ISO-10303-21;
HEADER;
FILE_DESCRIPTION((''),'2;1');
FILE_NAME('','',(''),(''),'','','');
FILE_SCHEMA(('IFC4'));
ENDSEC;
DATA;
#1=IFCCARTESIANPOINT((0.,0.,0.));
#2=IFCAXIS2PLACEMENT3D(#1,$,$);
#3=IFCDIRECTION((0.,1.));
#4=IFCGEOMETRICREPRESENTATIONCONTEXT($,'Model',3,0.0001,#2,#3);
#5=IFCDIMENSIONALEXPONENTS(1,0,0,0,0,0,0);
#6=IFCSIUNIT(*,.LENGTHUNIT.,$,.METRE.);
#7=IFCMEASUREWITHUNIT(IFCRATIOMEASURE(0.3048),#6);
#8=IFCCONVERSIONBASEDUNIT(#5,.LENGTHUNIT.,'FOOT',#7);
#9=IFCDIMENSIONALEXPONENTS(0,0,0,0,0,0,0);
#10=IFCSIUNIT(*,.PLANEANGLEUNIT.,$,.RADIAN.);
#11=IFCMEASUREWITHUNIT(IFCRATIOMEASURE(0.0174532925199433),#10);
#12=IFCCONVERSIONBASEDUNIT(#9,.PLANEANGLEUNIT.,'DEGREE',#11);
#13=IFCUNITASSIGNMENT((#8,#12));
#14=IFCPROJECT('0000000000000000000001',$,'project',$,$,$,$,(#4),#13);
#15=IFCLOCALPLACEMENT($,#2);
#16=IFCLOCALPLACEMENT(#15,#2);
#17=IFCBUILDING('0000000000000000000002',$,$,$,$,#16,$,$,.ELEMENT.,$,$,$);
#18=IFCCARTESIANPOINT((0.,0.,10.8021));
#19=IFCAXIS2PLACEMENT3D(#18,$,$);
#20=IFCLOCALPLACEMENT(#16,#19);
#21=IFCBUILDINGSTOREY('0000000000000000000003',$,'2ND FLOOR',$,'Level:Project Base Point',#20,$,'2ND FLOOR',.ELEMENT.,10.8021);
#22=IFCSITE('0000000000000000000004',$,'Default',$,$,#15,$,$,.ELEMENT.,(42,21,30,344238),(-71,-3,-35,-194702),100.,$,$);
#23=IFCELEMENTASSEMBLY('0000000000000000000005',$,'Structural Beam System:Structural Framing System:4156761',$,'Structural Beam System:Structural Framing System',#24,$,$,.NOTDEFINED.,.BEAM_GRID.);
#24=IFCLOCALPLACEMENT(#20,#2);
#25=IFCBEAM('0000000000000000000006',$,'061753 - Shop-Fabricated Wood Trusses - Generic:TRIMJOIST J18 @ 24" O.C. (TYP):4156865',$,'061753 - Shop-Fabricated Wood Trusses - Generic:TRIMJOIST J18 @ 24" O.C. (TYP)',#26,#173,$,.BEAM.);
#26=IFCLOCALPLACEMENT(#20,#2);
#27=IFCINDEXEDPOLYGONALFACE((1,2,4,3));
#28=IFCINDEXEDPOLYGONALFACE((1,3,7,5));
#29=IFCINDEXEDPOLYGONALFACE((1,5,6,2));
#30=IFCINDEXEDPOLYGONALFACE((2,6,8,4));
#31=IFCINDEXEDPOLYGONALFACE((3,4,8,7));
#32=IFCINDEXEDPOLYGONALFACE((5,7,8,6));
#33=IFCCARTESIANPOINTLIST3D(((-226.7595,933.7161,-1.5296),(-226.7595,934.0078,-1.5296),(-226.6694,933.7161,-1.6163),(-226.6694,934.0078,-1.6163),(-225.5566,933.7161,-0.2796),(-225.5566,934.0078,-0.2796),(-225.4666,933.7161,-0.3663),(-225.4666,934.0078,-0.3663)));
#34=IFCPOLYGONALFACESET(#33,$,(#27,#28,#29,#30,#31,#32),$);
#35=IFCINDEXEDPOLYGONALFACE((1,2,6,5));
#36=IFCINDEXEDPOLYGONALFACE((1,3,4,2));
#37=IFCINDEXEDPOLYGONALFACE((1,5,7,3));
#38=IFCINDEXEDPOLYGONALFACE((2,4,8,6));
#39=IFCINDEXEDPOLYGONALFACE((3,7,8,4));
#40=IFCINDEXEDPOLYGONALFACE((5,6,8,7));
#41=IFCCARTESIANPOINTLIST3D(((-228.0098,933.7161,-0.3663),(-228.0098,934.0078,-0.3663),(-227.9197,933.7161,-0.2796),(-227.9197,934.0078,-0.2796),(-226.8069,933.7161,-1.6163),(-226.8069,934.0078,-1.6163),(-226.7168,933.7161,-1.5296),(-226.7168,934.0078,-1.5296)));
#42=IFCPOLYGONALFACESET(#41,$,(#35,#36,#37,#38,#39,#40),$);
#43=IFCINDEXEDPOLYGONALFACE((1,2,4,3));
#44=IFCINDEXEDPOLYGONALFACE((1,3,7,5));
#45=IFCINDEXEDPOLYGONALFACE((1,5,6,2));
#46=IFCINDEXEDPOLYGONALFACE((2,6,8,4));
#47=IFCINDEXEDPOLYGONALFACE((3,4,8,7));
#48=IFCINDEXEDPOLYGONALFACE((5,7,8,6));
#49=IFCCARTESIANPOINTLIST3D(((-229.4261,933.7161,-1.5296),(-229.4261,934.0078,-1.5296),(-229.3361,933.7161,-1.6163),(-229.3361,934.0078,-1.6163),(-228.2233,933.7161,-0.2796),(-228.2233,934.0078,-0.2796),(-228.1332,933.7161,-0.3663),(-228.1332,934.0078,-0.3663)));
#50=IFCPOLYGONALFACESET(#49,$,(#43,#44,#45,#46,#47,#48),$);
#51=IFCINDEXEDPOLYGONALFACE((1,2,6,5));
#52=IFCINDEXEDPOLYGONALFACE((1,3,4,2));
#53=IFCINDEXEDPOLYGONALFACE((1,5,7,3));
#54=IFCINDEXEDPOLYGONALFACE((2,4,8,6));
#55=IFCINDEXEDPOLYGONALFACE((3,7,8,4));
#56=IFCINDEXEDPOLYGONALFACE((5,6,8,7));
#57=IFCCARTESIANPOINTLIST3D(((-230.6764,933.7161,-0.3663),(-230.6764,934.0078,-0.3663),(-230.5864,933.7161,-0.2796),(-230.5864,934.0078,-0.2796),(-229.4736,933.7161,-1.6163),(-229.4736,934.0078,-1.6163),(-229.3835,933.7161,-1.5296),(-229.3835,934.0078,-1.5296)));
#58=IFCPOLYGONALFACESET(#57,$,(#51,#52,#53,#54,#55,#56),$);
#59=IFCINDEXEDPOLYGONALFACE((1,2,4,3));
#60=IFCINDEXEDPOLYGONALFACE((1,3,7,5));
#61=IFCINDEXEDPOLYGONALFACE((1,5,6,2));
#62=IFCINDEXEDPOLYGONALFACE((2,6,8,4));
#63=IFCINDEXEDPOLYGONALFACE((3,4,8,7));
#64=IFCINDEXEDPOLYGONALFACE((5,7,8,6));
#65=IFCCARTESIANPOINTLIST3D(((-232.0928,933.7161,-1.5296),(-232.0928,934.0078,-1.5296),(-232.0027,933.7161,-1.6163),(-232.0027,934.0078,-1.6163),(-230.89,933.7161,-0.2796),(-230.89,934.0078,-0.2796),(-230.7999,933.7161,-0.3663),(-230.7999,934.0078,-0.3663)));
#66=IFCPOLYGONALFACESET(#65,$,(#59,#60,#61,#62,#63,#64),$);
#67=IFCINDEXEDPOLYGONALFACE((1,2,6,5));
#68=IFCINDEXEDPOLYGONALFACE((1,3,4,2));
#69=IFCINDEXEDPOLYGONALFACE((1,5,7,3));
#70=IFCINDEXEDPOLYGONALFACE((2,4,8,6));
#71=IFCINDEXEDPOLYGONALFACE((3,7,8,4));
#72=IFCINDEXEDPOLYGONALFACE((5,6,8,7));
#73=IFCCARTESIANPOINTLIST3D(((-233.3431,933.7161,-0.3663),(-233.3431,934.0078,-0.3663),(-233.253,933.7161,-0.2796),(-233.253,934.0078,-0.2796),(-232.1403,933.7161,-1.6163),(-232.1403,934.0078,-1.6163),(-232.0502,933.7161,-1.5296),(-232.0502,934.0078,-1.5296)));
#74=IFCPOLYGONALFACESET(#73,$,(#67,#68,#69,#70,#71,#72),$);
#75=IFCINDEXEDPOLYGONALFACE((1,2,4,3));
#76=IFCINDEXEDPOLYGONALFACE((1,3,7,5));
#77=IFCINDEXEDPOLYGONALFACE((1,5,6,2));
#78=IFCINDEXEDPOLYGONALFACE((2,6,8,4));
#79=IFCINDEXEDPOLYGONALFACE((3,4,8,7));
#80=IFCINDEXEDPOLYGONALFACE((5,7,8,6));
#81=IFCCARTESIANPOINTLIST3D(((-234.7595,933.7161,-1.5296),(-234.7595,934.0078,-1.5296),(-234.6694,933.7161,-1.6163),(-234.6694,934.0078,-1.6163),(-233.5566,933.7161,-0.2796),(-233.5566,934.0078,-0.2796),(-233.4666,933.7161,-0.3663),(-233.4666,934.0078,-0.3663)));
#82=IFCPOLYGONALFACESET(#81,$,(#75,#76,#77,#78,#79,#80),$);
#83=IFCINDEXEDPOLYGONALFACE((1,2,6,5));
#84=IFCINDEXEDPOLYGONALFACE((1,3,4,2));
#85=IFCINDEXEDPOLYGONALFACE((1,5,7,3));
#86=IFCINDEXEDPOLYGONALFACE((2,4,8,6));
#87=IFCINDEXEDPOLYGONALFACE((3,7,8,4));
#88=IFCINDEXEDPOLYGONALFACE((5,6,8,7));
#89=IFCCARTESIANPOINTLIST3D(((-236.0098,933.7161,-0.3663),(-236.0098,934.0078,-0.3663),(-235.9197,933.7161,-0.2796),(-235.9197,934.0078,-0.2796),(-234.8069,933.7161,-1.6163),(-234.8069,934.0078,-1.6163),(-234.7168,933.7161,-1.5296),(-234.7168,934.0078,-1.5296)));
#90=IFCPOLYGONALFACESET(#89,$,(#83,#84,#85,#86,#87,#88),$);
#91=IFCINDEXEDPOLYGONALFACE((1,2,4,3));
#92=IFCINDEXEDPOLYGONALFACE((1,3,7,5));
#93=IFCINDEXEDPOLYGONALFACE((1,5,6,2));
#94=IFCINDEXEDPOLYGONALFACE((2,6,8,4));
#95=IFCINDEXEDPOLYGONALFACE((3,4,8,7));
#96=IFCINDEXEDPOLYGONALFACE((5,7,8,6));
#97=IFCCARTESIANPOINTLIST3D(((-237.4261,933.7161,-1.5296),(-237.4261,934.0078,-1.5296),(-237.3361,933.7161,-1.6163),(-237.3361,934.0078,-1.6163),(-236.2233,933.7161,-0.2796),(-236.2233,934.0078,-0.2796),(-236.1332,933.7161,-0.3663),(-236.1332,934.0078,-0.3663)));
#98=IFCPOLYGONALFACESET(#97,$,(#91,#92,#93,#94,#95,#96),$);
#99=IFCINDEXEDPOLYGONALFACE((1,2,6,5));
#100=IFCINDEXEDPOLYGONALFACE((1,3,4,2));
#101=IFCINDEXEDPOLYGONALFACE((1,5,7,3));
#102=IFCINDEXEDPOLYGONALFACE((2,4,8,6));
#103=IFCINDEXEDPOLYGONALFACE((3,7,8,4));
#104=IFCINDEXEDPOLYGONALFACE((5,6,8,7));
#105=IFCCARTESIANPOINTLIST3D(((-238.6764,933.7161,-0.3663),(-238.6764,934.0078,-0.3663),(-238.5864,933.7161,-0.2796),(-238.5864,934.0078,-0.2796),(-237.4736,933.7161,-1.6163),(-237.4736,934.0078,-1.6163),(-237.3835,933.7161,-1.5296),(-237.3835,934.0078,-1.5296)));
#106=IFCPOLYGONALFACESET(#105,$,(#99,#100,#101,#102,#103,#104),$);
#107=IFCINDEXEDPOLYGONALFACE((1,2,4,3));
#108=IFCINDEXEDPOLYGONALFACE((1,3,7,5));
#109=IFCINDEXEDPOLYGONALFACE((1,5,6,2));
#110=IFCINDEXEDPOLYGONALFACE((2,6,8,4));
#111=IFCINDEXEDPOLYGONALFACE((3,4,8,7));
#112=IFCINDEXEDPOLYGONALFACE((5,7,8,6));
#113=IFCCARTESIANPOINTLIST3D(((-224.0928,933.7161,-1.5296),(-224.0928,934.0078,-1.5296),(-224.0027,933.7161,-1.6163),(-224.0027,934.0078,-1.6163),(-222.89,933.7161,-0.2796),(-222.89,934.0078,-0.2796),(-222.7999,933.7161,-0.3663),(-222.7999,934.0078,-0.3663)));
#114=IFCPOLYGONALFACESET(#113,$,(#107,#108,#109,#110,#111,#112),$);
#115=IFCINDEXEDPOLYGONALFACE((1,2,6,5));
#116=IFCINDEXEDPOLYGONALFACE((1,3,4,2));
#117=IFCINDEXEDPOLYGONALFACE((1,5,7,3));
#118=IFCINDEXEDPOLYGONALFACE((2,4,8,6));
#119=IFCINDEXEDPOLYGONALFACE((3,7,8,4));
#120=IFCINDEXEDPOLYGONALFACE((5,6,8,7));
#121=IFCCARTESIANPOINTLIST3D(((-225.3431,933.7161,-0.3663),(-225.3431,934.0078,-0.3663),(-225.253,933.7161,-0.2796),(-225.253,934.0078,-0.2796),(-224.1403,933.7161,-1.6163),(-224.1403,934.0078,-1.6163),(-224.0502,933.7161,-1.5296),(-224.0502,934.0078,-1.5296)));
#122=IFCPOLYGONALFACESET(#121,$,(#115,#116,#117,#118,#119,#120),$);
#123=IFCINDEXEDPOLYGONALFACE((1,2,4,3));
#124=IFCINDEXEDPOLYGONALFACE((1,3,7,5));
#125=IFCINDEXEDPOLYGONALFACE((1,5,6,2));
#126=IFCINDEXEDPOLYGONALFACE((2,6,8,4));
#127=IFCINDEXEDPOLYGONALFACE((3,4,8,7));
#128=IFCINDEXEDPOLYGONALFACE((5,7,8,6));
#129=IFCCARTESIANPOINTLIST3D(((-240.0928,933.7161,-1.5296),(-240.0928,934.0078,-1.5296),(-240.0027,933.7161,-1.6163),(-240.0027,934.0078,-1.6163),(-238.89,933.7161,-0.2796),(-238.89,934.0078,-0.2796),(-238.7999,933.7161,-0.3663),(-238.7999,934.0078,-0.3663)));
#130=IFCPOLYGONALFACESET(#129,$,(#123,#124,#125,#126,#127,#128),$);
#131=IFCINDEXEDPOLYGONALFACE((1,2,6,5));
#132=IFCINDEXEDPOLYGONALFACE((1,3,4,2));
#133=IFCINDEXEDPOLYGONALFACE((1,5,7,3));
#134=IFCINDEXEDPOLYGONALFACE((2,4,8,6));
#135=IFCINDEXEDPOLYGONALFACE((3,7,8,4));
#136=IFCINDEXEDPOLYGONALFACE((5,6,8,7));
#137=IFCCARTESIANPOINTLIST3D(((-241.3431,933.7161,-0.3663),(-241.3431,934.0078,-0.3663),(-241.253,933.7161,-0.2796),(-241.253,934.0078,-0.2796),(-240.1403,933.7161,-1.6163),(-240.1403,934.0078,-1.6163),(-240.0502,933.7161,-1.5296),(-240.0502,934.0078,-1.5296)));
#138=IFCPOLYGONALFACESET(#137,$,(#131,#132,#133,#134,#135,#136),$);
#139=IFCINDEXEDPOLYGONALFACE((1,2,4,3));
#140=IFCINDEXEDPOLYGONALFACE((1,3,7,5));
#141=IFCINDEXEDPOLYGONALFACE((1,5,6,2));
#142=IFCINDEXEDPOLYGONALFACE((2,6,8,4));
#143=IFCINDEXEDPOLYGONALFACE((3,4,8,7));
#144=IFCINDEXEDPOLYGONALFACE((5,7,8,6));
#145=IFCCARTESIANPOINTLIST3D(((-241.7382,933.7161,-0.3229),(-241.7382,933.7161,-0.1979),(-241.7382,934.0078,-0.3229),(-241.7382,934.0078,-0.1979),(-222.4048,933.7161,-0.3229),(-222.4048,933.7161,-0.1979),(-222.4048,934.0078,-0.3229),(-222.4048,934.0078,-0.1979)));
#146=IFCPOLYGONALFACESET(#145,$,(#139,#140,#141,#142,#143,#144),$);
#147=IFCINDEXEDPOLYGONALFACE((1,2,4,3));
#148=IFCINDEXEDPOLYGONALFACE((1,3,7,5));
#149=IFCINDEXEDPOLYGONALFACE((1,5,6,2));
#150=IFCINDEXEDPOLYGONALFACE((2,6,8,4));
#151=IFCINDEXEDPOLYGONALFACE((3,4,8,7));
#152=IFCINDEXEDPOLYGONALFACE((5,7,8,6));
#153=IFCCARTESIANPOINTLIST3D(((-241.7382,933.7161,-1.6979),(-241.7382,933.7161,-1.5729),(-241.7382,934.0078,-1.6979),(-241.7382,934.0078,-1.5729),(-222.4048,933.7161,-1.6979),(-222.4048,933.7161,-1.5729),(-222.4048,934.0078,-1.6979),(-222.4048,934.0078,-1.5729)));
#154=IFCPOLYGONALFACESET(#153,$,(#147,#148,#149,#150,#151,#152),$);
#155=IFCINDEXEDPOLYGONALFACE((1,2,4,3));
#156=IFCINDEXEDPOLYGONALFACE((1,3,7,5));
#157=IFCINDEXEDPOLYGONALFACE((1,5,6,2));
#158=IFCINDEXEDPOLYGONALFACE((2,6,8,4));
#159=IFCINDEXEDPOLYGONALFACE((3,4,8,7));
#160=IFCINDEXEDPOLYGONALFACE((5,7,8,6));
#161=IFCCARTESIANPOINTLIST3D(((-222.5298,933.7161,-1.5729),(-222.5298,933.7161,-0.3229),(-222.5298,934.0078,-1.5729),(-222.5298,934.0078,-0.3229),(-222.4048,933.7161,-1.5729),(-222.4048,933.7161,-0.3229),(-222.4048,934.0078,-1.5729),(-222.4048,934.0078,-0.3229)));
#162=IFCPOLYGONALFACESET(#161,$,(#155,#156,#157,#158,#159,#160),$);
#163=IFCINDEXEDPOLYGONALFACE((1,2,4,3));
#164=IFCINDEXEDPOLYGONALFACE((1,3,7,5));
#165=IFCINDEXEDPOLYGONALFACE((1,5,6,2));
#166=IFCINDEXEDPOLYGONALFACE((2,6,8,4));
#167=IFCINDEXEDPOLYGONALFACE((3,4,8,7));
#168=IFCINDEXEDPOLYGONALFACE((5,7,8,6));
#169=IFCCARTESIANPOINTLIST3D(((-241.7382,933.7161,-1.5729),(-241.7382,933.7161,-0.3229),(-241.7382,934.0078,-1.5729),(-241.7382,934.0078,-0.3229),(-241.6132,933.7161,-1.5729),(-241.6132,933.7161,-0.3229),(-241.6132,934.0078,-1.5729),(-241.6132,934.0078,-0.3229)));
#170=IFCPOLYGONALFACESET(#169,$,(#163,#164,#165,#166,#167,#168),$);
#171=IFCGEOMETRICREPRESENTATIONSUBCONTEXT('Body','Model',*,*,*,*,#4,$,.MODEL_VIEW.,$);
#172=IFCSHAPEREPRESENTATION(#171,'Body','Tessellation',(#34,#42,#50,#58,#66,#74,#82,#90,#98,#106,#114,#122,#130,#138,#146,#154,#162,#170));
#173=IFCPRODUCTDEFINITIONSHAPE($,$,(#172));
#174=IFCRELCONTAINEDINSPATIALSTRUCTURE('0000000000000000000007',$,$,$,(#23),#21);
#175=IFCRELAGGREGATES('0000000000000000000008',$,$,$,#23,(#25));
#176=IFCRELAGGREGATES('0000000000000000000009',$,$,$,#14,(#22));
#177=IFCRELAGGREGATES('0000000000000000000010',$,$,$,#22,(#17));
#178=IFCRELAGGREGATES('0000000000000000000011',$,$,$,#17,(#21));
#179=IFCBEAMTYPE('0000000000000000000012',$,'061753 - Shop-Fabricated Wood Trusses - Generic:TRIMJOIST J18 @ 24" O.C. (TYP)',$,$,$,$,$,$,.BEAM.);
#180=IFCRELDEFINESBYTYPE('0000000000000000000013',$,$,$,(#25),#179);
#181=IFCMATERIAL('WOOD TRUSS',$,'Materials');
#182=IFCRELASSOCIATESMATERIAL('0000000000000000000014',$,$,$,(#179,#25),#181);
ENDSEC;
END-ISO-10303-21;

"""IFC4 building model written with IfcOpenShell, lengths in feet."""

from ifc_helpers import new_model, entity, si_unit, converted_unit, direction, frame, frame_2d, origin, origin_2d_with_axis, place, context, subcontext, project, spatial, rectangle, extrude, source, transform, mapped, material, material_profile, profile_set, profile_usage, type_object, type_shapes, element, aggregate, save


model = new_model("IFC4")

# Units and contexts
model_context = context("Model", 3, precision=0.0001, world=origin(), true_north=direction((0.0, 1.0)))
body_context = subcontext(model_context, "Body", "Model", "MODEL_VIEW")
ifc_project = project(units=[converted_unit("LENGTHUNIT", "FOOT", entity("IfcRatioMeasure", 0.3048), si_unit("LENGTHUNIT", "METRE"), dimensions=[1, 0, 0, 0, 0, 0, 0]), converted_unit("PLANEANGLEUNIT", "DEGREE", entity("IfcRatioMeasure", 0.0174532925199433), si_unit("PLANEANGLEUNIT", "RADIAN"), dimensions=[0, 0, 0, 0, 0, 0, 0])], contexts=[model_context])

# Site, building, storey
site_placement = place(None, origin())
site = spatial("IfcSite", under=ifc_project, at=site_placement, Name="Default", CompositionType="ELEMENT", RefLatitude=(42, 21, 30, 344238), RefLongitude=(-71, -3, -35, -194702), RefElevation=100.0)
building_placement = place(site_placement, origin())
building = spatial("IfcBuilding", under=site, at=building_placement, CompositionType="ELEMENT")
storey_placement = place(building_placement, frame((0.0, 0.0, 10.8021)))
storey = spatial("IfcBuildingStorey", under=building, at=storey_placement, Name="2ND FLOOR", ObjectType="Level:Project Base Point", LongName="2ND FLOOR", CompositionType="ELEMENT", Elevation=10.8021)

# Element assembly, beam
ifc_material_1 = material(Name="WOOD TRUSS", Category="Materials")
ifc_material_profile_1 = material_profile(ifc_material_1, rectangle(XDim=1.7347, YDim=0.125, at=frame_2d((0.0, 0.0), x_axis=(1.0, 0.0))), Name="TRIMJOIST J18 @ 24\" O.C. (TYP)")
ifc_material_profile_2 = material_profile(ifc_material_1, rectangle(XDim=1.7347, YDim=0.125, at=frame_2d((0.0, 0.0), x_axis=(1.0, 0.0))), Name="TRIMJOIST J18 @ 24\" O.C. (TYP)")
ifc_material_profile_3 = material_profile(ifc_material_1, rectangle(XDim=1.7347, YDim=0.125, at=frame_2d((0.0, 0.0), x_axis=(1.0, 0.0))), Name="TRIMJOIST J18 @ 24\" O.C. (TYP)")
ifc_material_profile_4 = material_profile(ifc_material_1, rectangle(XDim=1.7347, YDim=0.125, at=frame_2d((0.0, 0.0), x_axis=(1.0, 0.0))), Name="TRIMJOIST J18 @ 24\" O.C. (TYP)")
ifc_material_profile_5 = material_profile(ifc_material_1, rectangle(XDim=1.7347, YDim=0.125, at=frame_2d((0.0, 0.0), x_axis=(1.0, 0.0))), Name="TRIMJOIST J18 @ 24\" O.C. (TYP)")
ifc_material_profile_6 = material_profile(ifc_material_1, rectangle(XDim=1.7347, YDim=0.125, at=frame_2d((0.0, 0.0), x_axis=(1.0, 0.0))), Name="TRIMJOIST J18 @ 24\" O.C. (TYP)")
ifc_material_profile_7 = material_profile(ifc_material_1, rectangle(XDim=1.7347, YDim=0.125, at=frame_2d((0.0, 0.0), x_axis=(1.0, 0.0))), Name="TRIMJOIST J18 @ 24\" O.C. (TYP)")
ifc_material_profile_8 = material_profile(ifc_material_1, rectangle(XDim=1.7347, YDim=0.125, at=frame_2d((0.0, 0.0), x_axis=(1.0, 0.0))), Name="TRIMJOIST J18 @ 24\" O.C. (TYP)")
ifc_material_profile_9 = material_profile(ifc_material_1, rectangle(XDim=1.7347, YDim=0.125, at=frame_2d((0.0, 0.0), x_axis=(1.0, 0.0))), Name="TRIMJOIST J18 @ 24\" O.C. (TYP)")
ifc_material_profile_10 = material_profile(ifc_material_1, rectangle(XDim=1.7347, YDim=0.125, at=origin_2d_with_axis()), Name="TRIMJOIST J18 @ 24\" O.C. (TYP)")
ifc_material_profile_11 = material_profile(ifc_material_1, rectangle(XDim=0.125, YDim=0.2917, at=origin_2d_with_axis()), Name="TRIMJOIST J18 @ 24\" O.C. (TYP)")
ifc_material_profile_12 = material_profile(ifc_material_1, rectangle(XDim=0.125, YDim=0.2917, at=origin_2d_with_axis()), Name="TRIMJOIST J18 @ 24\" O.C. (TYP)")
ifc_material_profile_13 = material_profile(ifc_material_1, rectangle(XDim=1.25, YDim=0.2917, at=origin_2d_with_axis()), Name="TRIMJOIST J18 @ 24\" O.C. (TYP)")
ifc_material_profile_14 = material_profile(ifc_material_1, rectangle(XDim=1.25, YDim=0.2917, at=origin_2d_with_axis()), Name="TRIMJOIST J18 @ 24\" O.C. (TYP)")
ifc_profile_set_1 = profile_set([ifc_material_profile_1, ifc_material_profile_2, ifc_material_profile_3, ifc_material_profile_4, ifc_material_profile_5, ifc_material_profile_6, ifc_material_profile_7, ifc_material_profile_8, ifc_material_profile_9, ifc_material_profile_10, ifc_material_profile_11, ifc_material_profile_12, ifc_material_profile_13, ifc_material_profile_14], Name="TRIMJOIST J18 @ 24\" O.C. (TYP)")
assembly_1_placement = place(storey_placement, origin())
assembly_1 = element("IfcElementAssembly", 1, at=assembly_1_placement, inside=storey, Name="Structural Beam System:Structural Framing System:4156761", ObjectType="Structural Beam System:Structural Framing System", AssemblyPlace="NOTDEFINED", PredefinedType="BEAM_GRID")
beam_type_1 = type_object("IfcBeamType", Name="061753 - Shop-Fabricated Wood Trusses - Generic:TRIMJOIST J18 @ 24\" O.C. (TYP)", PredefinedType="BEAM", material=ifc_profile_set_1)
shared_shape_1 = source(origin(), body_context, "Body", "SweptSolid", [
    extrude(rectangle(XDim=1.7347, YDim=0.125, at=frame_2d((0.0, 0.0), x_axis=(1.0, 0.0))), frame((5.9585, -0.1458, 0.0), z_axis=(0.0, 1.0, 0.0), x_axis=(0.693383, 0.0, 0.720569)), (0.0, 0.0, 1.0), 0.2917),
    extrude(rectangle(XDim=1.7347, YDim=0.125, at=origin_2d_with_axis()), frame((4.7082, -0.1458, 0.0), z_axis=(0.0, 1.0, 0.0), x_axis=(0.693383, 0.0, -0.720569)), (0.0, 0.0, 1.0), 0.2917),
    extrude(rectangle(XDim=1.7347, YDim=0.125, at=frame_2d((0.0, 0.0), x_axis=(1.0, 0.0))), frame((3.2918, -0.1458, 0.0), z_axis=(0.0, 1.0, 0.0), x_axis=(0.693383, 0.0, 0.720569)), (0.0, 0.0, 1.0), 0.2917),
    extrude(rectangle(XDim=1.7347, YDim=0.125, at=frame_2d((0.0, 0.0), x_axis=(1.0, 0.0))), frame((2.0415, -0.1458, 0.0), z_axis=(0.0, 1.0, 0.0), x_axis=(0.693383, 0.0, -0.720569)), (0.0, 0.0, 1.0), 0.2917),
    extrude(rectangle(XDim=1.7347, YDim=0.125, at=frame_2d((0.0, 0.0), x_axis=(1.0, 0.0))), frame((0.6251, -0.1458, 0.0), z_axis=(0.0, 1.0, 0.0), x_axis=(0.693383, 0.0, 0.720569)), (0.0, 0.0, 1.0), 0.2917),
    extrude(rectangle(XDim=1.7347, YDim=0.125, at=frame_2d((0.0, 0.0), x_axis=(1.0, 0.0))), frame((-0.6251, -0.1458, 0.0), z_axis=(0.0, 1.0, 0.0), x_axis=(0.693383, 0.0, -0.720569)), (0.0, 0.0, 1.0), 0.2917),
    extrude(rectangle(XDim=1.7347, YDim=0.125, at=frame_2d((0.0, 0.0), x_axis=(1.0, 0.0))), frame((-2.0415, -0.1458, 0.0), z_axis=(0.0, 1.0, 0.0), x_axis=(0.693383, 0.0, 0.720569)), (0.0, 0.0, 1.0), 0.2917),
    extrude(rectangle(XDim=1.7347, YDim=0.125, at=origin_2d_with_axis()), frame((-3.2918, -0.1458, 0.0), z_axis=(0.0, 1.0, 0.0), x_axis=(0.693383, 0.0, -0.720569)), (0.0, 0.0, 1.0), 0.2917),
    extrude(rectangle(XDim=1.7347, YDim=0.125, at=frame_2d((0.0, 0.0), x_axis=(1.0, 0.0))), frame((-4.7082, -0.1458, 0.0), z_axis=(0.0, 1.0, 0.0), x_axis=(0.693383, 0.0, 0.720569)), (0.0, 0.0, 1.0), 0.2917),
    extrude(rectangle(XDim=1.7347, YDim=0.125, at=frame_2d((0.0, 0.0), x_axis=(1.0, 0.0))), frame((-5.9585, -0.1458, 0.0), z_axis=(0.0, 1.0, 0.0), x_axis=(0.693383, 0.0, -0.720569)), (0.0, 0.0, 1.0), 0.2917),
    extrude(rectangle(XDim=1.7347, YDim=0.125, at=frame_2d((0.0, 0.0), x_axis=(1.0, 0.0))), frame((8.6251, -0.1458, 0.0), z_axis=(0.0, 1.0, 0.0), x_axis=(0.693383, 0.0, 0.720569)), (0.0, 0.0, 1.0), 0.2917),
    extrude(rectangle(XDim=1.7347, YDim=0.125, at=origin_2d_with_axis()), frame((7.3749, -0.1458, 0.0), z_axis=(0.0, 1.0, 0.0), x_axis=(0.693383, 0.0, -0.720569)), (0.0, 0.0, 1.0), 0.2917),
    extrude(rectangle(XDim=1.7347, YDim=0.125, at=frame_2d((0.0, 0.0), x_axis=(1.0, 0.0))), frame((-7.3749, -0.1458, 0.0), z_axis=(0.0, 1.0, 0.0), x_axis=(0.693383, 0.0, 0.720569)), (0.0, 0.0, 1.0), 0.2917),
    extrude(rectangle(XDim=1.7347, YDim=0.125, at=origin_2d_with_axis()), frame((-8.6251, -0.1458, 0.0), z_axis=(0.0, 1.0, 0.0), x_axis=(0.693383, 0.0, -0.720569)), (0.0, 0.0, 1.0), 0.2917),
    extrude(rectangle(XDim=0.125, YDim=0.2917, at=origin_2d_with_axis()), frame((-9.6667, 0.0, 0.6875), z_axis=(1.0, 0.0, 0.0), x_axis=(0.0, 0.0, -1.0)), (0.0, 0.0, 1.0), 19.3333),
    extrude(rectangle(XDim=0.125, YDim=0.2917, at=origin_2d_with_axis()), frame((-9.6667, 0.0, -0.6875), z_axis=(1.0, 0.0, 0.0), x_axis=(0.0, 0.0, -1.0)), (0.0, 0.0, 1.0), 19.3333),
    extrude(rectangle(XDim=1.25, YDim=0.2917, at=origin_2d_with_axis()), frame((9.5417, 0.0, 0.0), z_axis=(1.0, 0.0, 0.0), x_axis=(0.0, 0.0, -1.0)), (0.0, 0.0, 1.0), 0.125),
    extrude(rectangle(XDim=1.25, YDim=0.2917, at=origin_2d_with_axis()), frame((-9.6667, 0.0, 0.0), z_axis=(1.0, 0.0, 0.0), x_axis=(0.0, 0.0, -1.0)), (0.0, 0.0, 1.0), 0.125),
])
type_shapes(beam_type_1, [shared_shape_1])
ifc_profile_usage_1 = profile_usage(ifc_profile_set_1, cardinal=8)
beam_1_placement = place(assembly_1_placement, frame((-232.0715, 933.8619, -0.9479)))
beam_1 = element("IfcBeam", 2, at=beam_1_placement, type_object=beam_type_1, material=ifc_profile_usage_1, Name="061753 - Shop-Fabricated Wood Trusses - Generic:TRIMJOIST J18 @ 24\" O.C. (TYP):4156865", ObjectType="061753 - Shop-Fabricated Wood Trusses - Generic:TRIMJOIST J18 @ 24\" O.C. (TYP)", PredefinedType="BEAM", context=body_context, shape_type="MappedRepresentation", body=[
    mapped(shared_shape_1, transform((0.0, 0.0, 0.0), scale=1.0)),
])
aggregate(assembly_1, [beam_1])

save(model, "model.ifc")
